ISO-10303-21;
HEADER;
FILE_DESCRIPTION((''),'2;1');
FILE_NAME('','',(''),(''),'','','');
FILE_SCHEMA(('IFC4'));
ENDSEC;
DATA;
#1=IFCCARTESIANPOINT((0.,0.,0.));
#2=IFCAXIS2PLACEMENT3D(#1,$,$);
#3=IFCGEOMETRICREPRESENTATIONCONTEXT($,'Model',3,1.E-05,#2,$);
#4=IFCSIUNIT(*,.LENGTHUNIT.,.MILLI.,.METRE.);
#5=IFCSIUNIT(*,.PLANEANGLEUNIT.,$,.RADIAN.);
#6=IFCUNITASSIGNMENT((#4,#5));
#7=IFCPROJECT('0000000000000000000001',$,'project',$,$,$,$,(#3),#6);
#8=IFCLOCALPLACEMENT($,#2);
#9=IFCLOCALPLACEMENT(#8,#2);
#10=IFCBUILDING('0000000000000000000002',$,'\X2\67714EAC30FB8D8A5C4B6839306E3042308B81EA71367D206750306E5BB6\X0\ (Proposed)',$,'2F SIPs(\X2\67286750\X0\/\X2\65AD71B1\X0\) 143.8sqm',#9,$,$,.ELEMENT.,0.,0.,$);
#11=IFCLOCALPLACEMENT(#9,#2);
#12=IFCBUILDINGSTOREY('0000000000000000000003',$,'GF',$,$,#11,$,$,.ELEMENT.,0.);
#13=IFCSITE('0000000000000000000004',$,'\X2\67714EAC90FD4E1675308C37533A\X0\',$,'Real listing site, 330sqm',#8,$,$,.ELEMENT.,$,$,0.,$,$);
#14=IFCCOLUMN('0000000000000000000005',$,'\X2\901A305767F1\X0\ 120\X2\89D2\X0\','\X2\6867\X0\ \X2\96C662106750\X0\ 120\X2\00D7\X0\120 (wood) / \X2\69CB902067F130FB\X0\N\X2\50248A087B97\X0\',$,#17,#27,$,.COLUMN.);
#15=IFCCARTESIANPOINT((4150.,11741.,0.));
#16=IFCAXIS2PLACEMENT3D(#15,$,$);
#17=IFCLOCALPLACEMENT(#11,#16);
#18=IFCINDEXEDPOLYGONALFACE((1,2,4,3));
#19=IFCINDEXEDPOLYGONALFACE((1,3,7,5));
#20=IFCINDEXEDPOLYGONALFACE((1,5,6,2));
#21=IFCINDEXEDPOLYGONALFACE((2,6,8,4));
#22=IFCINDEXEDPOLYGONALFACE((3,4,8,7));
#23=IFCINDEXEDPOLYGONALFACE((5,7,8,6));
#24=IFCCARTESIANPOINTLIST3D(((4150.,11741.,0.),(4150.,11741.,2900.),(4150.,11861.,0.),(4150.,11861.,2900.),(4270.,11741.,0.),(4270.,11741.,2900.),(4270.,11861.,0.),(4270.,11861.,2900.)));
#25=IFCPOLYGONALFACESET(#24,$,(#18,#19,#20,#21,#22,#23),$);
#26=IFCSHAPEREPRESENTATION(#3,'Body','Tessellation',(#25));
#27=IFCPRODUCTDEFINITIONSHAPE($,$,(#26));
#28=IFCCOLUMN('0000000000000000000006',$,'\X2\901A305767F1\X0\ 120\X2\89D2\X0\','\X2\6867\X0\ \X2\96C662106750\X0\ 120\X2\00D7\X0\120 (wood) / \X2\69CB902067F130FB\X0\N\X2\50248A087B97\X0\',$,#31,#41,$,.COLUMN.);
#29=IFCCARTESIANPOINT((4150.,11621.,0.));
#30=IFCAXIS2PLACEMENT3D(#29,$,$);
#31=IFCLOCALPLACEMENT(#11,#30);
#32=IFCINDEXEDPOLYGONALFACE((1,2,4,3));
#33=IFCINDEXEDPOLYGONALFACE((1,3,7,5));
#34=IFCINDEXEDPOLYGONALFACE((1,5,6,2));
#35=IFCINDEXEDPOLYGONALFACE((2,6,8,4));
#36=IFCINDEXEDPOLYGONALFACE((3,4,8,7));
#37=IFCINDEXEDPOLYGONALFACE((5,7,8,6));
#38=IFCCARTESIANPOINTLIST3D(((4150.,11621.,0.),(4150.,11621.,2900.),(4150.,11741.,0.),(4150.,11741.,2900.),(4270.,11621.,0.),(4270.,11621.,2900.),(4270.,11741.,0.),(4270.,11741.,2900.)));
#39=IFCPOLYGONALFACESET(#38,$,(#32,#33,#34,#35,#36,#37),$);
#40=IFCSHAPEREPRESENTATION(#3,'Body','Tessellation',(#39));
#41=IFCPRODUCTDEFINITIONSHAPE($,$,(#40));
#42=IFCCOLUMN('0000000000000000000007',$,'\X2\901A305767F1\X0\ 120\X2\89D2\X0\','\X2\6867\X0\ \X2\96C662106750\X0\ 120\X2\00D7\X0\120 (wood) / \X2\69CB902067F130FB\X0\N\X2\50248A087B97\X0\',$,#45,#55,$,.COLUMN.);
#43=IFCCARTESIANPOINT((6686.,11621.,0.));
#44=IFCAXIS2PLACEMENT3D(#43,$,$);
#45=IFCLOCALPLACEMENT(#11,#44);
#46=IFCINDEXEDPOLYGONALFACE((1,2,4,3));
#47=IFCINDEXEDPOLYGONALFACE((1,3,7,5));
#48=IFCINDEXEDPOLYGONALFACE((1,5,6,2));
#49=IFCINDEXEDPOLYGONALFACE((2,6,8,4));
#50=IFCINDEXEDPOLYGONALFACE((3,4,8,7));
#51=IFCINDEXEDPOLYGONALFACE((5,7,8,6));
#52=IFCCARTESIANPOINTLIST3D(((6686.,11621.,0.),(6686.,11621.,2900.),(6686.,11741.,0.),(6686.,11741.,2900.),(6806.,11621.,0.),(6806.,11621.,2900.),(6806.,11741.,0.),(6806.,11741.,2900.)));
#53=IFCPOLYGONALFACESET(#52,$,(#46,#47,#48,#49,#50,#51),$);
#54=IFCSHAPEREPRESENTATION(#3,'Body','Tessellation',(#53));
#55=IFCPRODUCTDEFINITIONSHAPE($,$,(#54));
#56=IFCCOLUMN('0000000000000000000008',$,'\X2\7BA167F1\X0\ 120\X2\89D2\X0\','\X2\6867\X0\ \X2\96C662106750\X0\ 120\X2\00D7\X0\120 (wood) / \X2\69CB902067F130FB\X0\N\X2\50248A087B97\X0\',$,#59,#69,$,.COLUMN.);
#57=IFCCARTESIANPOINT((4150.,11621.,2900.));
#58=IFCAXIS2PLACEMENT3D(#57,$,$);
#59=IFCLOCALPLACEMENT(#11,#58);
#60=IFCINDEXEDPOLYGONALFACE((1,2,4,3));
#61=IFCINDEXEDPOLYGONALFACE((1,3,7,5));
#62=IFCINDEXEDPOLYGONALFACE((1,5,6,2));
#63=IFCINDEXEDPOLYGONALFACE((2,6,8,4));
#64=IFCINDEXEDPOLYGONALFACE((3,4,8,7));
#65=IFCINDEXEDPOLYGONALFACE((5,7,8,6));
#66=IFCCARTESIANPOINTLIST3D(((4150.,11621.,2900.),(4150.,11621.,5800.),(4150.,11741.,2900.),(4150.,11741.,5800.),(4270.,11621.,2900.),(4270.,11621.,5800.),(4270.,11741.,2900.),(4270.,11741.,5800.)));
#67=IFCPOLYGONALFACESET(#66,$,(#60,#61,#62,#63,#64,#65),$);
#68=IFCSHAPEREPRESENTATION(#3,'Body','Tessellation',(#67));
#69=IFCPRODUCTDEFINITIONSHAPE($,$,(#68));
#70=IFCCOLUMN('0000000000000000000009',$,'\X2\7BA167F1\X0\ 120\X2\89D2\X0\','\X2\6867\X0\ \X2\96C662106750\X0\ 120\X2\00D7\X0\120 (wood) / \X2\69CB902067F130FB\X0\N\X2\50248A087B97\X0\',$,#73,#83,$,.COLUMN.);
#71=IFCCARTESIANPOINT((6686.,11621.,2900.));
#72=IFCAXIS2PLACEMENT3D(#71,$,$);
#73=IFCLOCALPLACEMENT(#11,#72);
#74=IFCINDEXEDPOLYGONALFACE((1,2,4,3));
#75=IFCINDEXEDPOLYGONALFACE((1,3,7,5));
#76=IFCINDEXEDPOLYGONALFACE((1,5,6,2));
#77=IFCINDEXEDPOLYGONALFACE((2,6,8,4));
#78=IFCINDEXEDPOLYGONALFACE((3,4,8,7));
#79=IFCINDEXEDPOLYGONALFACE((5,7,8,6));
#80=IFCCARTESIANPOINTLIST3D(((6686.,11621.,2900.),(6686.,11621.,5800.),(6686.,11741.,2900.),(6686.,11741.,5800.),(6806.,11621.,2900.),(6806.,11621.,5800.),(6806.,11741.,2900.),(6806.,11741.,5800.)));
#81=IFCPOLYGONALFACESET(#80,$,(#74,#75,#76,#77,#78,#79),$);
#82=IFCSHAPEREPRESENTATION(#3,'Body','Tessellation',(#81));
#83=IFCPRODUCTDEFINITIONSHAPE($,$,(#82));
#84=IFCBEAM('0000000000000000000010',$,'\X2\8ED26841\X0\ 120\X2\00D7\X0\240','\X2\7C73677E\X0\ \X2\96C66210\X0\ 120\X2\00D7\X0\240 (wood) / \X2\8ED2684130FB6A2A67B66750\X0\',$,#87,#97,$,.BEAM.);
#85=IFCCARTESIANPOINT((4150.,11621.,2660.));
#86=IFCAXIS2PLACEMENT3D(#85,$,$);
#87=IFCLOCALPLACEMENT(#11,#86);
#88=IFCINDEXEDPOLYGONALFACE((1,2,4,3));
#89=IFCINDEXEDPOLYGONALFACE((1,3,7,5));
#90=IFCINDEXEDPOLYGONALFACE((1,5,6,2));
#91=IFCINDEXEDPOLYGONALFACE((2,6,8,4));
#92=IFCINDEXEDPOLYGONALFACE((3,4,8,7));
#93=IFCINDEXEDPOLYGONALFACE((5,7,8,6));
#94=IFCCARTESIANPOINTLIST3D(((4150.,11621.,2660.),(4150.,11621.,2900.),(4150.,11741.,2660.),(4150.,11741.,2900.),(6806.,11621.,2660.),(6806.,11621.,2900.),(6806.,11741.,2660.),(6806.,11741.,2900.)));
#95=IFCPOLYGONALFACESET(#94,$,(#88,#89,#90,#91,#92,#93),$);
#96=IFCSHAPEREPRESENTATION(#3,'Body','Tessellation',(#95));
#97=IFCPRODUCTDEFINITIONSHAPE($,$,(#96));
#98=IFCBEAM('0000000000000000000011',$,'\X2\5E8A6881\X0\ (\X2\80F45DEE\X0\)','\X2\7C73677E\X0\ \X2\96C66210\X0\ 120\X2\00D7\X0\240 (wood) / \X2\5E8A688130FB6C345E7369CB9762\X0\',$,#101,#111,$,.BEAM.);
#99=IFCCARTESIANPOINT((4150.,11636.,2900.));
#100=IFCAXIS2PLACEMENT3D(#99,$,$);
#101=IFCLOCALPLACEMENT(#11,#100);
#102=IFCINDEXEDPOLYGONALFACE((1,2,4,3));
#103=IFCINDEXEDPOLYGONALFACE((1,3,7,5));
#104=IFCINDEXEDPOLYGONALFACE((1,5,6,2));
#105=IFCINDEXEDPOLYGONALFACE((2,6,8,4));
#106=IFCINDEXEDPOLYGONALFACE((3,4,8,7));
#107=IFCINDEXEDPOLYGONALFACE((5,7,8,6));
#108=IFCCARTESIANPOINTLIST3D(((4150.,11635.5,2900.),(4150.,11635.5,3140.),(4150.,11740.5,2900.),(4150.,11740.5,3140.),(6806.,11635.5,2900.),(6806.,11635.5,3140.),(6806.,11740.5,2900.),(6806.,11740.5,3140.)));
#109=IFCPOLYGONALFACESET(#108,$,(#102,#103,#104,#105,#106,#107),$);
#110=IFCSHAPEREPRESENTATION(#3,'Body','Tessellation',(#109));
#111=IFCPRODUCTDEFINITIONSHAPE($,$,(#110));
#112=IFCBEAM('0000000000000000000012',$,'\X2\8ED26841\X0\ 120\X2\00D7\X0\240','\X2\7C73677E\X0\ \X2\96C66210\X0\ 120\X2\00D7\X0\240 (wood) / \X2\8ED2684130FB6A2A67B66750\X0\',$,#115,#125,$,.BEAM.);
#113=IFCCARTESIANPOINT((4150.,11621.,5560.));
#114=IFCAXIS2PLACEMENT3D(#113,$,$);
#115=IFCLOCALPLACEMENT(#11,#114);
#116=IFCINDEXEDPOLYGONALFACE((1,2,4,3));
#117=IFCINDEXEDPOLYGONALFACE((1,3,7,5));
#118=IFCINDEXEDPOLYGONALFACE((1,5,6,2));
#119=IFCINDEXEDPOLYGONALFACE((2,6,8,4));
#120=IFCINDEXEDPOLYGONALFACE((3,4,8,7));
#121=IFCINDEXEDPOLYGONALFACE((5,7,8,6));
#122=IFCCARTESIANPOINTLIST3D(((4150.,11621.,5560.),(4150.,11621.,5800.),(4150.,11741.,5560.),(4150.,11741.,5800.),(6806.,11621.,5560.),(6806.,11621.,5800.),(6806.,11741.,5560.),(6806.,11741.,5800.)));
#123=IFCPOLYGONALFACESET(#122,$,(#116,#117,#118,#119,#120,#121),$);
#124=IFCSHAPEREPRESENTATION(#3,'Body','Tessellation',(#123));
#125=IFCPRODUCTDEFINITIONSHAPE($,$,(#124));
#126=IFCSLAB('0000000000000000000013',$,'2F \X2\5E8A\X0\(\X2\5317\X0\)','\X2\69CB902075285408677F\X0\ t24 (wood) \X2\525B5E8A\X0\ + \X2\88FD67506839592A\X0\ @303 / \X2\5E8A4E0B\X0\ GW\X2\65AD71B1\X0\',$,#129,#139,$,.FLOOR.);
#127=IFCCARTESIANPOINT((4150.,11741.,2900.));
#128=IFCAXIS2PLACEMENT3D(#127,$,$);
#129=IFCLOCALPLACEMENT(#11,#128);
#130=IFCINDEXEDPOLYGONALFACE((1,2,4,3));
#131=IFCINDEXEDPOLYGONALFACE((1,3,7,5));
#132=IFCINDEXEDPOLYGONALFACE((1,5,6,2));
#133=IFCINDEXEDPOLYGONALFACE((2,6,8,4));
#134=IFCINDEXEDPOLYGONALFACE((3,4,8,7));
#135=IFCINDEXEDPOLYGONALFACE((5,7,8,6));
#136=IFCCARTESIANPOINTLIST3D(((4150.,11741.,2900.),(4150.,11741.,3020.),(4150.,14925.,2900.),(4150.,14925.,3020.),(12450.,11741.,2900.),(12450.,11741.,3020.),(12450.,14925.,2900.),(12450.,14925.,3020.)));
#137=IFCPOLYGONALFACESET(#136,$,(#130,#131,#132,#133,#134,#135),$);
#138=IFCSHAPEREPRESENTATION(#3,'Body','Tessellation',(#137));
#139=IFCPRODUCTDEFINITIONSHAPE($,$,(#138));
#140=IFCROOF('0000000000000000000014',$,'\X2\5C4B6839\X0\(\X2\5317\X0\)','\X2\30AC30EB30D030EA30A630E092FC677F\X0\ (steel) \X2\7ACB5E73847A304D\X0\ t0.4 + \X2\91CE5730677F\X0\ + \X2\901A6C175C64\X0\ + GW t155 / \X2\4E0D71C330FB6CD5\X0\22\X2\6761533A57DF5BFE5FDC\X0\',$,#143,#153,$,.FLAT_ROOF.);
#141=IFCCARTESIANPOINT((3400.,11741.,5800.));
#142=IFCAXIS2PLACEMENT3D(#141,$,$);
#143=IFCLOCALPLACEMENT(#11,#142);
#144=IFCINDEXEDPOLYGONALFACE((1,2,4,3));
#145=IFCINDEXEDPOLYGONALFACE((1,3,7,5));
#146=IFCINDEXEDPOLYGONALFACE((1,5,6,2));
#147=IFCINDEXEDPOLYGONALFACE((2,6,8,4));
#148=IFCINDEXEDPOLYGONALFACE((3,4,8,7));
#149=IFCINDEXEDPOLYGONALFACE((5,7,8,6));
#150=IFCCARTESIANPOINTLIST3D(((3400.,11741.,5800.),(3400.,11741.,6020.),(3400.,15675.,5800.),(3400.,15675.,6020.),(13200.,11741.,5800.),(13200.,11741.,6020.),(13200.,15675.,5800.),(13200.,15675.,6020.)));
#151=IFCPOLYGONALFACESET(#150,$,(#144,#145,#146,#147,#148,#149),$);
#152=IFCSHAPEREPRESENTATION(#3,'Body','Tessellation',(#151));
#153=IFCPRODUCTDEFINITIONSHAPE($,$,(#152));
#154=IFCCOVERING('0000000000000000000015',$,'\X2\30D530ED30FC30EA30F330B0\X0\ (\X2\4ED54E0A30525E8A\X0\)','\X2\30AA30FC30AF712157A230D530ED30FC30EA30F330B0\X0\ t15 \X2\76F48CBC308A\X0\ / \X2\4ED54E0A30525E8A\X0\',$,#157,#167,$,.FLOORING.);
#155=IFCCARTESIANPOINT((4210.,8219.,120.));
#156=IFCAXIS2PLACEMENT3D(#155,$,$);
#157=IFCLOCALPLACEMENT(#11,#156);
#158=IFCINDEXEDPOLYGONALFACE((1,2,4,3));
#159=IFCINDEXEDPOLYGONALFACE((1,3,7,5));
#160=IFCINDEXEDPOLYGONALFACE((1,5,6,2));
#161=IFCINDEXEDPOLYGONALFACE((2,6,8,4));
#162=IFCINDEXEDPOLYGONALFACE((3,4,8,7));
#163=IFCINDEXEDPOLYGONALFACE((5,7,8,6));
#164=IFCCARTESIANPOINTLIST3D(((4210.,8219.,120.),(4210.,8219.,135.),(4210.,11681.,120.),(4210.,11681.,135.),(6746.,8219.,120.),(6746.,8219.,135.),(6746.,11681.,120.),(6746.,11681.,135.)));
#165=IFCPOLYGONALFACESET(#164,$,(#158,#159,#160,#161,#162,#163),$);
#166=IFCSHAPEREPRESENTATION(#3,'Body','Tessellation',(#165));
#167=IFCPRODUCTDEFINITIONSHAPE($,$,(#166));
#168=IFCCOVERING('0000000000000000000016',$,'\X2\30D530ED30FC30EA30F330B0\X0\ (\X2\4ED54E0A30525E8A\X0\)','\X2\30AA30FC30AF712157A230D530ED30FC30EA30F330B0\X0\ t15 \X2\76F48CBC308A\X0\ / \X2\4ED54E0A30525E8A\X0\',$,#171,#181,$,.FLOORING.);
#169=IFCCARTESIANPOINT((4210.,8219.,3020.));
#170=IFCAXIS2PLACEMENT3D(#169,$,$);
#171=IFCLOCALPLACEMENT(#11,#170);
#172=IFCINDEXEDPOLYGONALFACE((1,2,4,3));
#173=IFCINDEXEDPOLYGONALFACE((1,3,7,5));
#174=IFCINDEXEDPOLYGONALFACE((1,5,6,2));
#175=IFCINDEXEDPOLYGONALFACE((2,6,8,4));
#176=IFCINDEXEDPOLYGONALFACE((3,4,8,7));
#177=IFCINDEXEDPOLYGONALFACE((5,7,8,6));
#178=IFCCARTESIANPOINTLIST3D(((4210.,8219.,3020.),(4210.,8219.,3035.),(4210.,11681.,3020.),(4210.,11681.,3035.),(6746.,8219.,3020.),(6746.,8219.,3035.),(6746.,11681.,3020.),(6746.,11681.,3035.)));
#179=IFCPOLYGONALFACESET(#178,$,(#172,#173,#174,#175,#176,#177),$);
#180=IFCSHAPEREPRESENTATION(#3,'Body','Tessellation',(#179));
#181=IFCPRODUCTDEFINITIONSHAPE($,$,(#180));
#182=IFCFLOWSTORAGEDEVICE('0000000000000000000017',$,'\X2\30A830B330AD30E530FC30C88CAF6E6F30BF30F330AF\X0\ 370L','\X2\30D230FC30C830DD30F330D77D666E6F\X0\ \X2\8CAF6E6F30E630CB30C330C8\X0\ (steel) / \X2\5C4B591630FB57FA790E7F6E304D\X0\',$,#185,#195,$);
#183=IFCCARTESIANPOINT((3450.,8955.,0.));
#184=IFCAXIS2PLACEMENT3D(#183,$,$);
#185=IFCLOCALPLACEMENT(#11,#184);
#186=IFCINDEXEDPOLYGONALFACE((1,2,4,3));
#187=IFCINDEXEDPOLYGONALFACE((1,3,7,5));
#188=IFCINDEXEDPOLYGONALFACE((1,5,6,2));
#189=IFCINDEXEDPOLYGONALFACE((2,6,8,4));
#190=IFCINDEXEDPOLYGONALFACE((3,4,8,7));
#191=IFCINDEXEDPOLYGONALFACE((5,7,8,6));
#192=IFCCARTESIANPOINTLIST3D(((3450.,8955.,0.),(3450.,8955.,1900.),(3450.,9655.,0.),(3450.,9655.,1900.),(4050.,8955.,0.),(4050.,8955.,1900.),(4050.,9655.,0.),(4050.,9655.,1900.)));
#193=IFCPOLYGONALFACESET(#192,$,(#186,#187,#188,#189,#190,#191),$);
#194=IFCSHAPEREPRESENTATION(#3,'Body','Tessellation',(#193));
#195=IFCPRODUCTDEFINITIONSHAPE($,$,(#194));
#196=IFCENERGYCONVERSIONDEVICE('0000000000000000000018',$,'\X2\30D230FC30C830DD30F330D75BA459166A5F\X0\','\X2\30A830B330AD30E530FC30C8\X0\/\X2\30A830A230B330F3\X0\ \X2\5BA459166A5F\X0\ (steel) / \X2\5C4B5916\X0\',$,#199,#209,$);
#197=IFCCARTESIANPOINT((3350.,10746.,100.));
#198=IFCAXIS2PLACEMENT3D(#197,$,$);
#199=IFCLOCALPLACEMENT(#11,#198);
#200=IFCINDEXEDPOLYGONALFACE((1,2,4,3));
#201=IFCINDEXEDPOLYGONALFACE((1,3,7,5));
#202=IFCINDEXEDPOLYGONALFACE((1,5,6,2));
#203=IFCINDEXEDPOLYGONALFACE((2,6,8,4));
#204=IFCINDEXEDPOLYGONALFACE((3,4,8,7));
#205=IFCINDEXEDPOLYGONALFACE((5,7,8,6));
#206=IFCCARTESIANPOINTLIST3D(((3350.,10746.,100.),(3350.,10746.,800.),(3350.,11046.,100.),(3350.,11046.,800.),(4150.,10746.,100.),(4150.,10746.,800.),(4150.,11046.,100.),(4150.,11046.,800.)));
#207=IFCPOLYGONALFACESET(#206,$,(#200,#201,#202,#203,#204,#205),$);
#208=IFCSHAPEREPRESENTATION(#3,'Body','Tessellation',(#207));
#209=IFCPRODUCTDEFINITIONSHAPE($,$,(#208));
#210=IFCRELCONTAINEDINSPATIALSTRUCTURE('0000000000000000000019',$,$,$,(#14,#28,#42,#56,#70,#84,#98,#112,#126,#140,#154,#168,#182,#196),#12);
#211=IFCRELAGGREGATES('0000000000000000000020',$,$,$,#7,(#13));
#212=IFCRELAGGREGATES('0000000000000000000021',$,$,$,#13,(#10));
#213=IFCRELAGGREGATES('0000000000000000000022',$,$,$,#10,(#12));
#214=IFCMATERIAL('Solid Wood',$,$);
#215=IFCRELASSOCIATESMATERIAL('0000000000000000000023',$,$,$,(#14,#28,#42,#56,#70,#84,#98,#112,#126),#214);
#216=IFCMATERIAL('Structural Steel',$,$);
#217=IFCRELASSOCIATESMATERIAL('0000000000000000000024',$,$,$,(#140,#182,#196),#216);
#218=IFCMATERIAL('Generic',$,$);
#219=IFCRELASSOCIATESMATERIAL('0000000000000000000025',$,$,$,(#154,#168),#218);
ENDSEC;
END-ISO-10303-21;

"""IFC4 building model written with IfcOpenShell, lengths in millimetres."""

from ifc_helpers import new_model, si_unit, frame, frame_2d, origin, place, context, project, spatial, rectangle, extrude, material, element, save


model = new_model("IFC4")

# Units and contexts
model_context = context("Model", 3, precision=1e-05, world=origin())
ifc_project = project(units=[si_unit("LENGTHUNIT", "METRE", prefix="MILLI"), si_unit("PLANEANGLEUNIT", "RADIAN")], contexts=[model_context])

# Site, building, storey
site_placement = place(None, origin())
site = spatial("IfcSite", under=ifc_project, at=site_placement, Name="東京都世田谷区", ObjectType="Real listing site, 330sqm", CompositionType="ELEMENT", RefElevation=0.0)
building_placement = place(site_placement, origin())
building = spatial("IfcBuilding", under=site, at=building_placement, Name="東京・越屋根のある自然素材の家 (Proposed)", ObjectType="2F SIPs(木材/断熱) 143.8sqm", CompositionType="ELEMENT", ElevationOfRefHeight=0.0, ElevationOfTerrain=0.0)
storey_placement = place(building_placement, origin())
storey = spatial("IfcBuildingStorey", under=building, at=storey_placement, Name="GF", CompositionType="ELEMENT", Elevation=0.0)

# Columns
ifc_material_1 = material(Name="Solid Wood")
column_1_placement = place(storey_placement, frame((4150.0, 11741.0, 0.0)))
element("IfcColumn", 1, at=column_1_placement, inside=storey, material=ifc_material_1, Name="通し柱 120角", Description="桧 集成材 120×120 (wood) / 構造柱・N値計算", PredefinedType="COLUMN", context=model_context, shape_type="SweptSolid", body=[
    extrude(rectangle(XDim=120.0, YDim=120.0, at=frame_2d((60.0, 60.0))), frame((4150.0, 11741.0, 0.0)), (0.0, 0.0, 1.0), 2900.0),
])
column_2_placement = place(storey_placement, frame((4150.0, 11621.0, 0.0)))
element("IfcColumn", 2, at=column_2_placement, inside=storey, material=ifc_material_1, Name="通し柱 120角", Description="桧 集成材 120×120 (wood) / 構造柱・N値計算", PredefinedType="COLUMN", context=model_context, shape_type="SweptSolid", body=[
    extrude(rectangle(XDim=120.0, YDim=120.0, at=frame_2d((60.0, 60.0))), frame((4150.0, 11621.0, 0.0)), (0.0, 0.0, 1.0), 2900.0),
])
column_3_placement = place(storey_placement, frame((6686.0, 11621.0, 0.0)))
element("IfcColumn", 3, at=column_3_placement, inside=storey, material=ifc_material_1, Name="通し柱 120角", Description="桧 集成材 120×120 (wood) / 構造柱・N値計算", PredefinedType="COLUMN", context=model_context, shape_type="SweptSolid", body=[
    extrude(rectangle(XDim=120.0, YDim=120.0, at=frame_2d((60.0, 60.0))), frame((6686.0, 11621.0, 0.0)), (0.0, 0.0, 1.0), 2900.0),
])
column_4_placement = place(storey_placement, frame((4150.0, 11621.0, 2900.0)))
element("IfcColumn", 4, at=column_4_placement, inside=storey, material=ifc_material_1, Name="管柱 120角", Description="桧 集成材 120×120 (wood) / 構造柱・N値計算", PredefinedType="COLUMN", context=model_context, shape_type="SweptSolid", body=[
    extrude(rectangle(XDim=120.0, YDim=120.0, at=frame_2d((60.0, 60.0))), frame((4150.0, 11621.0, 2900.0)), (0.0, 0.0, 1.0), 2900.0),
])
column_5_placement = place(storey_placement, frame((6686.0, 11621.0, 2900.0)))
element("IfcColumn", 5, at=column_5_placement, inside=storey, material=ifc_material_1, Name="管柱 120角", Description="桧 集成材 120×120 (wood) / 構造柱・N値計算", PredefinedType="COLUMN", context=model_context, shape_type="SweptSolid", body=[
    extrude(rectangle(XDim=120.0, YDim=120.0, at=frame_2d((60.0, 60.0))), frame((6686.0, 11621.0, 2900.0)), (0.0, 0.0, 1.0), 2900.0),
])

# Beams
beam_1_placement = place(storey_placement, frame((4150.0, 11621.0, 2660.0)))
element("IfcBeam", 6, at=beam_1_placement, inside=storey, material=ifc_material_1, Name="軒桁 120×240", Description="米松 集成 120×240 (wood) / 軒桁・横架材", PredefinedType="BEAM", context=model_context, shape_type="SweptSolid", body=[
    extrude(rectangle(XDim=2656.0, YDim=120.0, at=frame_2d((1328.0, 60.0))), frame((4150.0, 11621.0, 2660.0)), (0.0, 0.0, 1.0), 240.0),
])
beam_2_placement = place(storey_placement, frame((4150.0, 11636.0, 2900.0)))
element("IfcBeam", 7, at=beam_2_placement, inside=storey, material=ifc_material_1, Name="床梁 (胴差)", Description="米松 集成 120×240 (wood) / 床梁・水平構面", PredefinedType="BEAM", context=model_context, shape_type="SweptSolid", body=[
    extrude(rectangle(XDim=2656.0, YDim=105.0, at=frame_2d((1328.0, 52.0))), frame((4150.0, 11636.0, 2900.0)), (0.0, 0.0, 1.0), 240.0),
])
beam_3_placement = place(storey_placement, frame((4150.0, 11621.0, 5560.0)))
element("IfcBeam", 8, at=beam_3_placement, inside=storey, material=ifc_material_1, Name="軒桁 120×240", Description="米松 集成 120×240 (wood) / 軒桁・横架材", PredefinedType="BEAM", context=model_context, shape_type="SweptSolid", body=[
    extrude(rectangle(XDim=2656.0, YDim=120.0, at=frame_2d((1328.0, 60.0))), frame((4150.0, 11621.0, 5560.0)), (0.0, 0.0, 1.0), 240.0),
])

# Slab
slab_1_placement = place(storey_placement, frame((4150.0, 11741.0, 2900.0)))
element("IfcSlab", 9, at=slab_1_placement, inside=storey, material=ifc_material_1, Name="2F 床(北)", Description="構造用合板 t24 (wood) 剛床 + 製材根太 @303 / 床下 GW断熱", PredefinedType="FLOOR", context=model_context, shape_type="SweptSolid", body=[
    extrude(rectangle(XDim=8300.0, YDim=3184.0, at=frame_2d((4150.0, 1592.0))), frame((4150.0, 11741.0, 2900.0)), (0.0, 0.0, 1.0), 120.0),
])

# Roof
ifc_material_2 = material(Name="Structural Steel")
for number, where, name in (
    (10, (3400.0, 11741.0, 5800.0), "屋根(北)"),
):
    element("IfcRoof", number, at=place(storey_placement, frame(where)), inside=storey, material=ifc_material_2, Name=name, Description="ガルバリウム鋼板 (steel) 立平葺き t0.4 + 野地板 + 通気層 + GW t155 / 不燃・法22条区域対応", PredefinedType="FLAT_ROOF", context=model_context, shape_type="SweptSolid", body=[
        extrude(rectangle(XDim=9800.0, YDim=3934.0, at=frame_2d((4900.0, 1967.0))), frame((3400.0, 11741.0, 5800.0)), (0.0, 0.0, 1.0), 220.0),
    ])

# Coverings
ifc_material_3 = material(Name="Generic")
covering_1_placement = place(storey_placement, frame((4210.0, 8219.0, 120.0)))
element("IfcCovering", 11, at=covering_1_placement, inside=storey, material=ifc_material_3, Name="フローリング (仕上げ床)", Description="オーク無垢フローリング t15 直貼り / 仕上げ床", PredefinedType="FLOORING", context=model_context, shape_type="SweptSolid", body=[
    extrude(rectangle(XDim=2536.0, YDim=3462.0, at=frame_2d((1268.0, 1731.0))), frame((4210.0, 8219.0, 120.0)), (0.0, 0.0, 1.0), 15.0),
])
covering_2_placement = place(storey_placement, frame((4210.0, 8219.0, 3020.0)))
element("IfcCovering", 12, at=covering_2_placement, inside=storey, material=ifc_material_3, Name="フローリング (仕上げ床)", Description="オーク無垢フローリング t15 直貼り / 仕上げ床", PredefinedType="FLOORING", context=model_context, shape_type="SweptSolid", body=[
    extrude(rectangle(XDim=2536.0, YDim=3462.0, at=frame_2d((1268.0, 1731.0))), frame((4210.0, 8219.0, 3020.0)), (0.0, 0.0, 1.0), 15.0),
])

# Flow storage device
flow_storage_device_placement = place(storey_placement, frame((3450.0, 8955.0, 0.0)))
element("IfcFlowStorageDevice", 13, at=flow_storage_device_placement, inside=storey, material=ifc_material_2, Name="エコキュート貯湯タンク 370L", Description="ヒートポンプ給湯 貯湯ユニット (steel) / 屋外・基礎置き", context=model_context, shape_type="SweptSolid", body=[
    extrude(rectangle(XDim=600.0, YDim=700.0, at=frame_2d((300.0, 350.0))), frame((3450.0, 8955.0, 0.0)), (0.0, 0.0, 1.0), 1900.0),
])

# Energy conversion device
energy_conversion_device_placement = place(storey_placement, frame((3350.0, 10746.0, 100.0)))
element("IfcEnergyConversionDevice", 14, at=energy_conversion_device_placement, inside=storey, material=ifc_material_2, Name="ヒートポンプ室外機", Description="エコキュート/エアコン 室外機 (steel) / 屋外", context=model_context, shape_type="SweptSolid", body=[
    extrude(rectangle(XDim=800.0, YDim=300.0, at=frame_2d((400.0, 150.0))), frame((3350.0, 10746.0, 100.0)), (0.0, 0.0, 1.0), 700.0),
])

save(model, "model.ifc")
